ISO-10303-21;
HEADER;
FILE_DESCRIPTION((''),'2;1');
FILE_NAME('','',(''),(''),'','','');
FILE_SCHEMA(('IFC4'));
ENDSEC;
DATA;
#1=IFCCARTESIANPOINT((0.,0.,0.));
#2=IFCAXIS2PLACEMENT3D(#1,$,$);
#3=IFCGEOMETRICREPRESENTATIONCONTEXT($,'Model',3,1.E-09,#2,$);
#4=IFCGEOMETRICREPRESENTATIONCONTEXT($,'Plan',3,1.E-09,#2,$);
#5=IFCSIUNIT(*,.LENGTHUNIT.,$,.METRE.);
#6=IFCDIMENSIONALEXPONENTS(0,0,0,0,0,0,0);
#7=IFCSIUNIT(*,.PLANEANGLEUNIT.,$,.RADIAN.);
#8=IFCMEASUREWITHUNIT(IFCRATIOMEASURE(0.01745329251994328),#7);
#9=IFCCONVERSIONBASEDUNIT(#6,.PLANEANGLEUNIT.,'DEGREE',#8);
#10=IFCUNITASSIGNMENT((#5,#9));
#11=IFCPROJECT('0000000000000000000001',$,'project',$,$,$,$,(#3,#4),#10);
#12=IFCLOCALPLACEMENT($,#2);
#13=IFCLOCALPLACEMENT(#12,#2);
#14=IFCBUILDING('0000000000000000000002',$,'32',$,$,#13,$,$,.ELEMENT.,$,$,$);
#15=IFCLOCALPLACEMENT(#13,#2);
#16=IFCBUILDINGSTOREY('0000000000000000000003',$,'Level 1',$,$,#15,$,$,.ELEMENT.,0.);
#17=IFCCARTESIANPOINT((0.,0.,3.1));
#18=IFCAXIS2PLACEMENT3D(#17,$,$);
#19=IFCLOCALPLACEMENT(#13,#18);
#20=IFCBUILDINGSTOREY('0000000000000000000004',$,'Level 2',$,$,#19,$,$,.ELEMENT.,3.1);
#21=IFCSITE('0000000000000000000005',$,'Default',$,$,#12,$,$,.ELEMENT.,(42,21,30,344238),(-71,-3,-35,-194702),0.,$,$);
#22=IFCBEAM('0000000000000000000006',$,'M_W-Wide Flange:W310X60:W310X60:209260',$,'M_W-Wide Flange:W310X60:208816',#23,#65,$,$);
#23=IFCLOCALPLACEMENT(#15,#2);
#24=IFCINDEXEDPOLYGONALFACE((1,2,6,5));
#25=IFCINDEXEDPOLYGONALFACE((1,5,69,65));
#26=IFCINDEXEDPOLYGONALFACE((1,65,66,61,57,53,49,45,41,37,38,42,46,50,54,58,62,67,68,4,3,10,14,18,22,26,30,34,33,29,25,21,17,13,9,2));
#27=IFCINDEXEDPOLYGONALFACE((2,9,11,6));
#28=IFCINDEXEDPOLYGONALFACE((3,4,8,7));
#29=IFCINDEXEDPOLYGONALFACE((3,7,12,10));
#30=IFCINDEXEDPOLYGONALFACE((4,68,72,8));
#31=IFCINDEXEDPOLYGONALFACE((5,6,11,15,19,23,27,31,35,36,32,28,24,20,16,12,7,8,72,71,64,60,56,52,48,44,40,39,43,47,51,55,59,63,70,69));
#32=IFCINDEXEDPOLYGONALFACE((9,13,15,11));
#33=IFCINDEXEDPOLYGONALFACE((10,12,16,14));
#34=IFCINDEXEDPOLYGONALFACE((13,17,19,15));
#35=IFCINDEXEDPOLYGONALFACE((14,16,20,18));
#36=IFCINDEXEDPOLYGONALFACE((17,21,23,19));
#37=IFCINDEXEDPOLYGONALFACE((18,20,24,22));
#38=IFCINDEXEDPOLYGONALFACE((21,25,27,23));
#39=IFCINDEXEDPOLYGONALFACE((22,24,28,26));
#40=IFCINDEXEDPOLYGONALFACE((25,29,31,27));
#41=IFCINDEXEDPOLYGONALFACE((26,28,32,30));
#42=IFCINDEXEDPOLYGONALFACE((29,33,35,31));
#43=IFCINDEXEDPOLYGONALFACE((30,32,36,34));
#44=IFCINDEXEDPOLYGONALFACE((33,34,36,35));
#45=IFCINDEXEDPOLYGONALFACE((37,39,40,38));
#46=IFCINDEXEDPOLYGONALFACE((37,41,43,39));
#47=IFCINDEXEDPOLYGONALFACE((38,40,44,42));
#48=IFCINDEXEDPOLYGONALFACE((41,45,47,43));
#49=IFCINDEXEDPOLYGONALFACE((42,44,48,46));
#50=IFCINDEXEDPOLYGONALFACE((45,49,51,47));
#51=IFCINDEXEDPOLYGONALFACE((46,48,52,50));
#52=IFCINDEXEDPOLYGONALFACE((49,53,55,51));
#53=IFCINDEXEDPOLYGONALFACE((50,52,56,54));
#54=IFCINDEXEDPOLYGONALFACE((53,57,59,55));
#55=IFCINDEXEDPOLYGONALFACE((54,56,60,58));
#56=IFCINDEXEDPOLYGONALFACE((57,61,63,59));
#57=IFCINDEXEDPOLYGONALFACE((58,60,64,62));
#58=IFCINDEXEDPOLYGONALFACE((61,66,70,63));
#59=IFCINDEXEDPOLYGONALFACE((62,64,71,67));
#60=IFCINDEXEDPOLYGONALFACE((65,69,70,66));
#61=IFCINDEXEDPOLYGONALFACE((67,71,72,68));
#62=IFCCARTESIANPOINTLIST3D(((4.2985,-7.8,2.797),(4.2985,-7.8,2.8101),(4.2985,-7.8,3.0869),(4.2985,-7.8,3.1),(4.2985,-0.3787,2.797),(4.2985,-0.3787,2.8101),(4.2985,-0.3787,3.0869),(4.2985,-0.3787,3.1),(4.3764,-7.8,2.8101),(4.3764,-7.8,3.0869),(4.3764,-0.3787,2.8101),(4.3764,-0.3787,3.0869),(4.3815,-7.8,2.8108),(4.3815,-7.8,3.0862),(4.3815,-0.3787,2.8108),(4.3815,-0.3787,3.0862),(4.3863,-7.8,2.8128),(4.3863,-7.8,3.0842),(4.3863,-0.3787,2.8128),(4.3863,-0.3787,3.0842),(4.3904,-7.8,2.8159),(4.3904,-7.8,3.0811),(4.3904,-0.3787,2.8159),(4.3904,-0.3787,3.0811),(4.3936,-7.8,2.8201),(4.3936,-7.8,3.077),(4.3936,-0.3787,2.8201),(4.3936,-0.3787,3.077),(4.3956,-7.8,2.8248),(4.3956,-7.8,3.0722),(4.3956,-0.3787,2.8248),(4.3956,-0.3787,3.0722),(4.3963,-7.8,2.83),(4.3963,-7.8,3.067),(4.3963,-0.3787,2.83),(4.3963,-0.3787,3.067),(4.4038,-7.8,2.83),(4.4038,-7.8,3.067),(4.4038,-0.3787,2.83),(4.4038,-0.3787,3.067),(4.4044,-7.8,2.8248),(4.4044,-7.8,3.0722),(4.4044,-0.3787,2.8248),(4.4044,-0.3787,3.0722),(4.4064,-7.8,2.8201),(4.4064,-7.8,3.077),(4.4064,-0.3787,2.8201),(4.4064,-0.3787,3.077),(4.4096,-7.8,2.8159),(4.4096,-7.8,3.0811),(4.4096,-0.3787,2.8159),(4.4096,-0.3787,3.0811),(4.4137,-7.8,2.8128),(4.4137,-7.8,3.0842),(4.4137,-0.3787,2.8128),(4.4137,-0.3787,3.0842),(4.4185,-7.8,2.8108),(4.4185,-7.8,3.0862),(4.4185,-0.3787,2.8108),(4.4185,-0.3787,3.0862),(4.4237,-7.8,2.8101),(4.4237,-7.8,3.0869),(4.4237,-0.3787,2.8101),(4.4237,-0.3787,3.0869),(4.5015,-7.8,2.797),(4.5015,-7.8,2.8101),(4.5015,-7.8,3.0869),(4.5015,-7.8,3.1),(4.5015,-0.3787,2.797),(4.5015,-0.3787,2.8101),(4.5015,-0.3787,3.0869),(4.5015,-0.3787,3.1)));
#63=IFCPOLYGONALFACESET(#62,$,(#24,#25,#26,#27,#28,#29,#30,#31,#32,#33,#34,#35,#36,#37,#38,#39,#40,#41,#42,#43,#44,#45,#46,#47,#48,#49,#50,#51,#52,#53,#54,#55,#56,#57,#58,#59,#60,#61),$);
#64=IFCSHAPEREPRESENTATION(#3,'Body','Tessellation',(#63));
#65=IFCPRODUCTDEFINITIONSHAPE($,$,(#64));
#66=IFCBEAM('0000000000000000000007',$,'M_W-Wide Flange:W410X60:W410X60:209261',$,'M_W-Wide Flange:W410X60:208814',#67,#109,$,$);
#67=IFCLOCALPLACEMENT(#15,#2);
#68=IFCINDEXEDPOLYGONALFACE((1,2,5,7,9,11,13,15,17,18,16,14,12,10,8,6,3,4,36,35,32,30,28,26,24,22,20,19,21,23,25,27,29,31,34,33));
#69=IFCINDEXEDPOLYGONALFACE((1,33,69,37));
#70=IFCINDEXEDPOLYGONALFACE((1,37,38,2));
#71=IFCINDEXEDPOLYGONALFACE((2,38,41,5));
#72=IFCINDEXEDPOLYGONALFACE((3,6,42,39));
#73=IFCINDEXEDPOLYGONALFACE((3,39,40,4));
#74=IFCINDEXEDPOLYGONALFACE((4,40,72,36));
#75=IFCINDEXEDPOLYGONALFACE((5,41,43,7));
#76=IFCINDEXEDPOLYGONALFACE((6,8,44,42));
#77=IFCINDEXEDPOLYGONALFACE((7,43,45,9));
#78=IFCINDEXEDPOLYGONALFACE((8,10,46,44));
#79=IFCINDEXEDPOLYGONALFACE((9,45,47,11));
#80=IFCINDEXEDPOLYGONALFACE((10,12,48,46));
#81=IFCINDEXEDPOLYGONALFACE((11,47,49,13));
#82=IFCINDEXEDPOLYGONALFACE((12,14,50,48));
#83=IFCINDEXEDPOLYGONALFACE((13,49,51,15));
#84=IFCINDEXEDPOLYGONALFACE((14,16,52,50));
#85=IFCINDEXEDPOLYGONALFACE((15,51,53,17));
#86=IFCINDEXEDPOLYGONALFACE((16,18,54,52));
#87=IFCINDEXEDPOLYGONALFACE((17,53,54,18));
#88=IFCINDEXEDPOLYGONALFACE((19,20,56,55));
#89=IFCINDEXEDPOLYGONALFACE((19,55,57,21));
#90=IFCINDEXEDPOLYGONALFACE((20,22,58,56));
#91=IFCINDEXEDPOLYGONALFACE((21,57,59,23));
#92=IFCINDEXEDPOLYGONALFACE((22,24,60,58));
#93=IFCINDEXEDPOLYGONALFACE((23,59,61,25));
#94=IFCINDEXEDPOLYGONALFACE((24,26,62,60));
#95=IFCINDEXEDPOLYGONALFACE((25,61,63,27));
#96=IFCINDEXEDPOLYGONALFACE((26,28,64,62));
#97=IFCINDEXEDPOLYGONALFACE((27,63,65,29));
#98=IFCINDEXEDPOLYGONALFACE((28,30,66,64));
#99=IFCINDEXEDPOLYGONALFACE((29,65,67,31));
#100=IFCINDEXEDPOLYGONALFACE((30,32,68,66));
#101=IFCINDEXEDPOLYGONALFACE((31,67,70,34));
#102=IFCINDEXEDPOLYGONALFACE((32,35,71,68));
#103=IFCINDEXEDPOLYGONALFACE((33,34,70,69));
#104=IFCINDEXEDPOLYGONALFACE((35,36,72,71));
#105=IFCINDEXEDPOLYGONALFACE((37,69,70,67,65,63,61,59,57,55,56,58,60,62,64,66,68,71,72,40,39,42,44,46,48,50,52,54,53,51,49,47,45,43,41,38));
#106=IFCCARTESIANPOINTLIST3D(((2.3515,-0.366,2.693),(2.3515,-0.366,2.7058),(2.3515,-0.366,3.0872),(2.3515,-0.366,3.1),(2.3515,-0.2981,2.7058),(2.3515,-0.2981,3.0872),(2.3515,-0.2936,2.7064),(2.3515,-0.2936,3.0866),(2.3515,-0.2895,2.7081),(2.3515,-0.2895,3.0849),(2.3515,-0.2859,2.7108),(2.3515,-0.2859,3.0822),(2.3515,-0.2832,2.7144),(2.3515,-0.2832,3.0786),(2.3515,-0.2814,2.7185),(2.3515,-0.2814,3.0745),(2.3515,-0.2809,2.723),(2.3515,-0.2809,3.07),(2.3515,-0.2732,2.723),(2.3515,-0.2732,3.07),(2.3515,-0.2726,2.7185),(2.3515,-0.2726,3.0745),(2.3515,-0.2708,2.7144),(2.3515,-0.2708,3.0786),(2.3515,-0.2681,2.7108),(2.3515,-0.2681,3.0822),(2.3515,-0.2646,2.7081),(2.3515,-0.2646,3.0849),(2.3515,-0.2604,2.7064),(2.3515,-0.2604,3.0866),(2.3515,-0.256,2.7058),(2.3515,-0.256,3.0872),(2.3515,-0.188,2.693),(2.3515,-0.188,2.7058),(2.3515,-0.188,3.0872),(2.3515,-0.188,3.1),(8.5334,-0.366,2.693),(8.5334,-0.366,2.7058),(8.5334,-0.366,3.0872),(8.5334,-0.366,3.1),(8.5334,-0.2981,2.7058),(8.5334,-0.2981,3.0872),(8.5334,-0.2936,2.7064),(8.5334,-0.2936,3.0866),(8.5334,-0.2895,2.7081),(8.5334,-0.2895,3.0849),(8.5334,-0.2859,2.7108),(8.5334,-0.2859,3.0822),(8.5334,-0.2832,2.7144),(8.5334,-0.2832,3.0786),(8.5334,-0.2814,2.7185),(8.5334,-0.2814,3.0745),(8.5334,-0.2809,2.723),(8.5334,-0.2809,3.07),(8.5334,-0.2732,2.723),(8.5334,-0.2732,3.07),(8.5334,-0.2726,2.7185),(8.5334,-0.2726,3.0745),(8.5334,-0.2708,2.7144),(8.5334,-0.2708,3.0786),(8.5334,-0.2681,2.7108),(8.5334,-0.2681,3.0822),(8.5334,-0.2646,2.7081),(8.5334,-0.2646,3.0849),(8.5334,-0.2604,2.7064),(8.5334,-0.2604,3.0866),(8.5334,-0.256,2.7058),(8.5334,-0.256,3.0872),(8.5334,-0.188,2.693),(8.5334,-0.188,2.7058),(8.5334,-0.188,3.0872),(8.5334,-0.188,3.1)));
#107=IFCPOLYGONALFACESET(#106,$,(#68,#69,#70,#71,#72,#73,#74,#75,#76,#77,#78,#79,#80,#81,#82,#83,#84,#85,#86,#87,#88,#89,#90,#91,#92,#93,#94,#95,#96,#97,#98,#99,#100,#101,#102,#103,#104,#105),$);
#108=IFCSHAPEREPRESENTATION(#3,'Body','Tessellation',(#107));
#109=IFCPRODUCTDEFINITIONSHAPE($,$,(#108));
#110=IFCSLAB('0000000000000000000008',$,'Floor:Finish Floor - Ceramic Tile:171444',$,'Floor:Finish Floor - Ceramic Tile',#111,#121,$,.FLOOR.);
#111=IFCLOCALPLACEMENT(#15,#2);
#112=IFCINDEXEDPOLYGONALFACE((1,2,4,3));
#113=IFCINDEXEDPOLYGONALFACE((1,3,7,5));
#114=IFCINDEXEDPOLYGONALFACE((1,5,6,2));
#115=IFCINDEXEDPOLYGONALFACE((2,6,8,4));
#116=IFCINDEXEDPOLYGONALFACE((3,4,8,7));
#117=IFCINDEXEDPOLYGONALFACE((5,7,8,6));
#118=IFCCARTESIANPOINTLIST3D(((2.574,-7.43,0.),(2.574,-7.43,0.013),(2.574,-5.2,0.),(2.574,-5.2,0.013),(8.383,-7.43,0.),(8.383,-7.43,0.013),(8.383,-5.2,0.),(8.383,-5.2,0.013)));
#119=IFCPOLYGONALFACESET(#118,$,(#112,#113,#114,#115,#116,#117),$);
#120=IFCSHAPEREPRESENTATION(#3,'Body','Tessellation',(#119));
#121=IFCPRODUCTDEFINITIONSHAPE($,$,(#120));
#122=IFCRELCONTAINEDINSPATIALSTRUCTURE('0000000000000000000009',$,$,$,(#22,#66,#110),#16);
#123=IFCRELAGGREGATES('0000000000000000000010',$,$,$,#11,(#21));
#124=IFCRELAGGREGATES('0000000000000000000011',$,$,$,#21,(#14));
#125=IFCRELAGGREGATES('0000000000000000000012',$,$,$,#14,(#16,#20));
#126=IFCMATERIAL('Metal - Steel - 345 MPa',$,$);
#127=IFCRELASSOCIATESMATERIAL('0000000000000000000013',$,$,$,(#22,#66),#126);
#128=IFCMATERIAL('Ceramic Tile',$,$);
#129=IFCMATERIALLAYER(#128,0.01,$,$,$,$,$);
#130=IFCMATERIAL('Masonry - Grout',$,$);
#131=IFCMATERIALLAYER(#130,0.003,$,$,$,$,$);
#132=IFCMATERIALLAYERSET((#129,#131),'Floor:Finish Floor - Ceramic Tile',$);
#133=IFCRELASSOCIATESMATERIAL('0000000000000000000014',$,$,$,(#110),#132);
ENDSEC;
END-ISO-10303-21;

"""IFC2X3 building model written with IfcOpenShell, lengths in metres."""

from ifc_helpers import new_model, entity, si_unit, converted_unit, frame, frame_2d, origin, place, context, project, spatial, polyline, circle_curve, parameter, trimmed, segment, composite_curve, rectangle, outline, extrude, material, layer, layer_set, layer_usage, element, save


model = new_model("IFC2X3")

# Units and contexts
model_context = context("Model", 3, precision=1e-09, world=origin())
plan_context = context("Plan", 3, precision=1e-09, world=origin())
ifc_project = project(units=[si_unit("LENGTHUNIT", "METRE"), converted_unit("PLANEANGLEUNIT", "DEGREE", entity("IfcRatioMeasure", 0.01745329251994328), si_unit("PLANEANGLEUNIT", "RADIAN"), dimensions=[0, 0, 0, 0, 0, 0, 0])], contexts=[model_context, plan_context])

# Site, building, storey
site_placement = place(None, origin())
site = spatial("IfcSite", under=ifc_project, at=site_placement, Name="Default", CompositionType="ELEMENT", RefLatitude=(42, 21, 30, 344238), RefLongitude=(-71, -3, -35, -194702), RefElevation=0.0)
building_placement = place(site_placement, origin())
building = spatial("IfcBuilding", under=site, at=building_placement, Name="32", CompositionType="ELEMENT")
storey_1_placement = place(building_placement, origin())
storey_1 = spatial("IfcBuildingStorey", under=building, at=storey_1_placement, Name="Level 1", CompositionType="ELEMENT", Elevation=0.0)

# Beams
ifc_material_1 = material(Name="Metal - Steel - 345 MPa")
beam_1_placement = place(storey_1_placement, frame((4.4, -7.8, 3.1)))
element("IfcBeam", 1, at=beam_1_placement, inside=storey_1, material=ifc_material_1, Name="M_W-Wide Flange:W310X60:W310X60:209260", ObjectType="M_W-Wide Flange:W310X60:208816", context=model_context, shape_type="SweptSolid", body=[
    extrude(outline(composite_curve([segment(polyline([(-0.1015, -0.1384), (-0.1015, -0.1515)]), True, "CONTINUOUS"), segment(polyline([(-0.1015, -0.1515), (0.1015, -0.1515)]), True, "CONTINUOUS"), segment(polyline([(0.1015, -0.1515), (0.1015, -0.1384)]), True, "CONTINUOUS"), segment(polyline([(0.1015, -0.1384), (0.0236, -0.1384)]), True, "CONTINUOUS"), segment(trimmed(circle_curve(frame_2d((0.0236, -0.1185), x_axis=(1.0, 0.0)), 0.0199), [parameter(180.0)], [parameter(270.0)], True, "PARAMETER"), False, "CONTINUOUS"), segment(polyline([(0.0037, -0.1185), (0.0037, 0.1185)]), True, "CONTINUOUS"), segment(trimmed(circle_curve(frame_2d((0.0236, 0.1185), x_axis=(1.0, 0.0)), 0.0199), [parameter(90.0)], [parameter(180.0)], True, "PARAMETER"), False, "CONTINUOUS"), segment(polyline([(0.0236, 0.1384), (0.1015, 0.1384)]), True, "CONTINUOUS"), segment(polyline([(0.1015, 0.1384), (0.1015, 0.1515)]), True, "CONTINUOUS"), segment(polyline([(0.1015, 0.1515), (-0.1015, 0.1515)]), True, "CONTINUOUS"), segment(polyline([(-0.1015, 0.1515), (-0.1015, 0.1384)]), True, "CONTINUOUS"), segment(polyline([(-0.1015, 0.1384), (-0.0237, 0.1384)]), True, "CONTINUOUS"), segment(trimmed(circle_curve(frame_2d((-0.0237, 0.1185), x_axis=(1.0, 0.0)), 0.0199), [parameter(360.0)], [parameter(90.0)], True, "PARAMETER"), False, "CONTINUOUS"), segment(polyline([(-0.0038, 0.1185), (-0.0038, -0.1185)]), True, "CONTINUOUS"), segment(trimmed(circle_curve(frame_2d((-0.0237, -0.1185), x_axis=(1.0, 0.0)), 0.0199), [parameter(270.0)], [parameter(0.0)], True, "PARAMETER"), False, "CONTINUOUS"), segment(polyline([(-0.0237, -0.1384), (-0.1015, -0.1384)]), True, "CONTINUOUS")], self_intersect=False)), frame((0.0, 0.0, -0.1515), z_axis=(0.0, -1.0, 0.0), x_axis=(1.0, 0.0, 0.0)), (0.0, 0.0, -1.0), 7.4213),
])
beam_2_placement = place(storey_1_placement, frame((8.5915, -0.277, 3.1), z_axis=(0.0, 0.0, 1.0), x_axis=(0.0, 1.0, 0.0)))
element("IfcBeam", 2, at=beam_2_placement, inside=storey_1, material=ifc_material_1, Name="M_W-Wide Flange:W410X60:W410X60:209261", ObjectType="M_W-Wide Flange:W410X60:208814", context=model_context, shape_type="SweptSolid", body=[
    extrude(outline(composite_curve([segment(polyline([(0.1907, -0.089), (0.2035, -0.089)]), True, "CONTINUOUS"), segment(polyline([(0.2035, -0.089), (0.2035, 0.089)]), True, "CONTINUOUS"), segment(polyline([(0.2035, 0.089), (0.1907, 0.089)]), True, "CONTINUOUS"), segment(polyline([(0.1907, 0.089), (0.1907, 0.021)]), True, "CONTINUOUS"), segment(trimmed(circle_curve(frame_2d((0.1735, 0.021), x_axis=(1.0, 0.0)), 0.0172), [parameter(270.0)], [parameter(360.0)], True, "PARAMETER"), False, "CONTINUOUS"), segment(polyline([(0.1735, 0.0038), (-0.1735, 0.0038)]), True, "CONTINUOUS"), segment(trimmed(circle_curve(frame_2d((-0.1735, 0.021), x_axis=(0.0, -1.0)), 0.0172), [parameter(270.0)], [parameter(360.0)], True, "PARAMETER"), False, "CONTINUOUS"), segment(polyline([(-0.1907, 0.021), (-0.1907, 0.089)]), True, "CONTINUOUS"), segment(polyline([(-0.1907, 0.089), (-0.2035, 0.089)]), True, "CONTINUOUS"), segment(polyline([(-0.2035, 0.089), (-0.2035, -0.089)]), True, "CONTINUOUS"), segment(polyline([(-0.2035, -0.089), (-0.1907, -0.089)]), True, "CONTINUOUS"), segment(polyline([(-0.1907, -0.089), (-0.1907, -0.0211)]), True, "CONTINUOUS"), segment(trimmed(circle_curve(frame_2d((-0.1735, -0.0211), x_axis=(-1.0, 0.0)), 0.0172), [parameter(270.0)], [parameter(0.0)], True, "PARAMETER"), False, "CONTINUOUS"), segment(polyline([(-0.1735, -0.0039), (0.1735, -0.0039)]), True, "CONTINUOUS"), segment(trimmed(circle_curve(frame_2d((0.1735, -0.0211), x_axis=(0.0, 1.0)), 0.0172), [parameter(270.0)], [parameter(0.0)], True, "PARAMETER"), False, "CONTINUOUS"), segment(polyline([(0.1907, -0.0211), (0.1907, -0.089)]), True, "CONTINUOUS")], self_intersect=False)), frame((0.0, 6.24, -0.2035), z_axis=(0.0, -1.0, 0.0), x_axis=(0.0, 0.0, -1.0)), (0.0, 0.0, 1.0), 6.1819),
])

# Slab
ifc_material_2 = material(Name="Ceramic Tile")
ifc_layer_1 = layer(ifc_material_2, 0.01)
ifc_material_3 = material(Name="Masonry - Grout")
ifc_layer_2 = layer(ifc_material_3, 0.003)
ifc_layer_set_1 = layer_set([ifc_layer_1, ifc_layer_2], Name="Floor:Finish Floor - Ceramic Tile")
ifc_layer_usage_1 = layer_usage(ifc_layer_set_1, "AXIS3", "POSITIVE", 0.0)
slab_1_placement = place(storey_1_placement, frame((2.574, -7.43, 0.0)))
element("IfcSlab", 3, at=slab_1_placement, inside=storey_1, material=ifc_layer_usage_1, Name="Floor:Finish Floor - Ceramic Tile:171444", ObjectType="Floor:Finish Floor - Ceramic Tile", PredefinedType="FLOOR", context=model_context, shape_type="SweptSolid", body=[
    extrude(rectangle(XDim=5.809, YDim=2.23, at=frame_2d((0.0, 0.0), x_axis=(-1.0, 0.0))), frame((2.9045, 1.115, 0.013), z_axis=(0.0, 0.0, -1.0), x_axis=(-1.0, 0.0, 0.0)), (0.0, 0.0, 1.0), 0.013),
])

# Shared definitions
storey_2_placement = place(building_placement, frame((0.0, 0.0, 3.1)))
storey_2 = spatial("IfcBuildingStorey", under=building, at=storey_2_placement, Name="Level 2", CompositionType="ELEMENT", Elevation=3.1)

save(model, "model.ifc")
